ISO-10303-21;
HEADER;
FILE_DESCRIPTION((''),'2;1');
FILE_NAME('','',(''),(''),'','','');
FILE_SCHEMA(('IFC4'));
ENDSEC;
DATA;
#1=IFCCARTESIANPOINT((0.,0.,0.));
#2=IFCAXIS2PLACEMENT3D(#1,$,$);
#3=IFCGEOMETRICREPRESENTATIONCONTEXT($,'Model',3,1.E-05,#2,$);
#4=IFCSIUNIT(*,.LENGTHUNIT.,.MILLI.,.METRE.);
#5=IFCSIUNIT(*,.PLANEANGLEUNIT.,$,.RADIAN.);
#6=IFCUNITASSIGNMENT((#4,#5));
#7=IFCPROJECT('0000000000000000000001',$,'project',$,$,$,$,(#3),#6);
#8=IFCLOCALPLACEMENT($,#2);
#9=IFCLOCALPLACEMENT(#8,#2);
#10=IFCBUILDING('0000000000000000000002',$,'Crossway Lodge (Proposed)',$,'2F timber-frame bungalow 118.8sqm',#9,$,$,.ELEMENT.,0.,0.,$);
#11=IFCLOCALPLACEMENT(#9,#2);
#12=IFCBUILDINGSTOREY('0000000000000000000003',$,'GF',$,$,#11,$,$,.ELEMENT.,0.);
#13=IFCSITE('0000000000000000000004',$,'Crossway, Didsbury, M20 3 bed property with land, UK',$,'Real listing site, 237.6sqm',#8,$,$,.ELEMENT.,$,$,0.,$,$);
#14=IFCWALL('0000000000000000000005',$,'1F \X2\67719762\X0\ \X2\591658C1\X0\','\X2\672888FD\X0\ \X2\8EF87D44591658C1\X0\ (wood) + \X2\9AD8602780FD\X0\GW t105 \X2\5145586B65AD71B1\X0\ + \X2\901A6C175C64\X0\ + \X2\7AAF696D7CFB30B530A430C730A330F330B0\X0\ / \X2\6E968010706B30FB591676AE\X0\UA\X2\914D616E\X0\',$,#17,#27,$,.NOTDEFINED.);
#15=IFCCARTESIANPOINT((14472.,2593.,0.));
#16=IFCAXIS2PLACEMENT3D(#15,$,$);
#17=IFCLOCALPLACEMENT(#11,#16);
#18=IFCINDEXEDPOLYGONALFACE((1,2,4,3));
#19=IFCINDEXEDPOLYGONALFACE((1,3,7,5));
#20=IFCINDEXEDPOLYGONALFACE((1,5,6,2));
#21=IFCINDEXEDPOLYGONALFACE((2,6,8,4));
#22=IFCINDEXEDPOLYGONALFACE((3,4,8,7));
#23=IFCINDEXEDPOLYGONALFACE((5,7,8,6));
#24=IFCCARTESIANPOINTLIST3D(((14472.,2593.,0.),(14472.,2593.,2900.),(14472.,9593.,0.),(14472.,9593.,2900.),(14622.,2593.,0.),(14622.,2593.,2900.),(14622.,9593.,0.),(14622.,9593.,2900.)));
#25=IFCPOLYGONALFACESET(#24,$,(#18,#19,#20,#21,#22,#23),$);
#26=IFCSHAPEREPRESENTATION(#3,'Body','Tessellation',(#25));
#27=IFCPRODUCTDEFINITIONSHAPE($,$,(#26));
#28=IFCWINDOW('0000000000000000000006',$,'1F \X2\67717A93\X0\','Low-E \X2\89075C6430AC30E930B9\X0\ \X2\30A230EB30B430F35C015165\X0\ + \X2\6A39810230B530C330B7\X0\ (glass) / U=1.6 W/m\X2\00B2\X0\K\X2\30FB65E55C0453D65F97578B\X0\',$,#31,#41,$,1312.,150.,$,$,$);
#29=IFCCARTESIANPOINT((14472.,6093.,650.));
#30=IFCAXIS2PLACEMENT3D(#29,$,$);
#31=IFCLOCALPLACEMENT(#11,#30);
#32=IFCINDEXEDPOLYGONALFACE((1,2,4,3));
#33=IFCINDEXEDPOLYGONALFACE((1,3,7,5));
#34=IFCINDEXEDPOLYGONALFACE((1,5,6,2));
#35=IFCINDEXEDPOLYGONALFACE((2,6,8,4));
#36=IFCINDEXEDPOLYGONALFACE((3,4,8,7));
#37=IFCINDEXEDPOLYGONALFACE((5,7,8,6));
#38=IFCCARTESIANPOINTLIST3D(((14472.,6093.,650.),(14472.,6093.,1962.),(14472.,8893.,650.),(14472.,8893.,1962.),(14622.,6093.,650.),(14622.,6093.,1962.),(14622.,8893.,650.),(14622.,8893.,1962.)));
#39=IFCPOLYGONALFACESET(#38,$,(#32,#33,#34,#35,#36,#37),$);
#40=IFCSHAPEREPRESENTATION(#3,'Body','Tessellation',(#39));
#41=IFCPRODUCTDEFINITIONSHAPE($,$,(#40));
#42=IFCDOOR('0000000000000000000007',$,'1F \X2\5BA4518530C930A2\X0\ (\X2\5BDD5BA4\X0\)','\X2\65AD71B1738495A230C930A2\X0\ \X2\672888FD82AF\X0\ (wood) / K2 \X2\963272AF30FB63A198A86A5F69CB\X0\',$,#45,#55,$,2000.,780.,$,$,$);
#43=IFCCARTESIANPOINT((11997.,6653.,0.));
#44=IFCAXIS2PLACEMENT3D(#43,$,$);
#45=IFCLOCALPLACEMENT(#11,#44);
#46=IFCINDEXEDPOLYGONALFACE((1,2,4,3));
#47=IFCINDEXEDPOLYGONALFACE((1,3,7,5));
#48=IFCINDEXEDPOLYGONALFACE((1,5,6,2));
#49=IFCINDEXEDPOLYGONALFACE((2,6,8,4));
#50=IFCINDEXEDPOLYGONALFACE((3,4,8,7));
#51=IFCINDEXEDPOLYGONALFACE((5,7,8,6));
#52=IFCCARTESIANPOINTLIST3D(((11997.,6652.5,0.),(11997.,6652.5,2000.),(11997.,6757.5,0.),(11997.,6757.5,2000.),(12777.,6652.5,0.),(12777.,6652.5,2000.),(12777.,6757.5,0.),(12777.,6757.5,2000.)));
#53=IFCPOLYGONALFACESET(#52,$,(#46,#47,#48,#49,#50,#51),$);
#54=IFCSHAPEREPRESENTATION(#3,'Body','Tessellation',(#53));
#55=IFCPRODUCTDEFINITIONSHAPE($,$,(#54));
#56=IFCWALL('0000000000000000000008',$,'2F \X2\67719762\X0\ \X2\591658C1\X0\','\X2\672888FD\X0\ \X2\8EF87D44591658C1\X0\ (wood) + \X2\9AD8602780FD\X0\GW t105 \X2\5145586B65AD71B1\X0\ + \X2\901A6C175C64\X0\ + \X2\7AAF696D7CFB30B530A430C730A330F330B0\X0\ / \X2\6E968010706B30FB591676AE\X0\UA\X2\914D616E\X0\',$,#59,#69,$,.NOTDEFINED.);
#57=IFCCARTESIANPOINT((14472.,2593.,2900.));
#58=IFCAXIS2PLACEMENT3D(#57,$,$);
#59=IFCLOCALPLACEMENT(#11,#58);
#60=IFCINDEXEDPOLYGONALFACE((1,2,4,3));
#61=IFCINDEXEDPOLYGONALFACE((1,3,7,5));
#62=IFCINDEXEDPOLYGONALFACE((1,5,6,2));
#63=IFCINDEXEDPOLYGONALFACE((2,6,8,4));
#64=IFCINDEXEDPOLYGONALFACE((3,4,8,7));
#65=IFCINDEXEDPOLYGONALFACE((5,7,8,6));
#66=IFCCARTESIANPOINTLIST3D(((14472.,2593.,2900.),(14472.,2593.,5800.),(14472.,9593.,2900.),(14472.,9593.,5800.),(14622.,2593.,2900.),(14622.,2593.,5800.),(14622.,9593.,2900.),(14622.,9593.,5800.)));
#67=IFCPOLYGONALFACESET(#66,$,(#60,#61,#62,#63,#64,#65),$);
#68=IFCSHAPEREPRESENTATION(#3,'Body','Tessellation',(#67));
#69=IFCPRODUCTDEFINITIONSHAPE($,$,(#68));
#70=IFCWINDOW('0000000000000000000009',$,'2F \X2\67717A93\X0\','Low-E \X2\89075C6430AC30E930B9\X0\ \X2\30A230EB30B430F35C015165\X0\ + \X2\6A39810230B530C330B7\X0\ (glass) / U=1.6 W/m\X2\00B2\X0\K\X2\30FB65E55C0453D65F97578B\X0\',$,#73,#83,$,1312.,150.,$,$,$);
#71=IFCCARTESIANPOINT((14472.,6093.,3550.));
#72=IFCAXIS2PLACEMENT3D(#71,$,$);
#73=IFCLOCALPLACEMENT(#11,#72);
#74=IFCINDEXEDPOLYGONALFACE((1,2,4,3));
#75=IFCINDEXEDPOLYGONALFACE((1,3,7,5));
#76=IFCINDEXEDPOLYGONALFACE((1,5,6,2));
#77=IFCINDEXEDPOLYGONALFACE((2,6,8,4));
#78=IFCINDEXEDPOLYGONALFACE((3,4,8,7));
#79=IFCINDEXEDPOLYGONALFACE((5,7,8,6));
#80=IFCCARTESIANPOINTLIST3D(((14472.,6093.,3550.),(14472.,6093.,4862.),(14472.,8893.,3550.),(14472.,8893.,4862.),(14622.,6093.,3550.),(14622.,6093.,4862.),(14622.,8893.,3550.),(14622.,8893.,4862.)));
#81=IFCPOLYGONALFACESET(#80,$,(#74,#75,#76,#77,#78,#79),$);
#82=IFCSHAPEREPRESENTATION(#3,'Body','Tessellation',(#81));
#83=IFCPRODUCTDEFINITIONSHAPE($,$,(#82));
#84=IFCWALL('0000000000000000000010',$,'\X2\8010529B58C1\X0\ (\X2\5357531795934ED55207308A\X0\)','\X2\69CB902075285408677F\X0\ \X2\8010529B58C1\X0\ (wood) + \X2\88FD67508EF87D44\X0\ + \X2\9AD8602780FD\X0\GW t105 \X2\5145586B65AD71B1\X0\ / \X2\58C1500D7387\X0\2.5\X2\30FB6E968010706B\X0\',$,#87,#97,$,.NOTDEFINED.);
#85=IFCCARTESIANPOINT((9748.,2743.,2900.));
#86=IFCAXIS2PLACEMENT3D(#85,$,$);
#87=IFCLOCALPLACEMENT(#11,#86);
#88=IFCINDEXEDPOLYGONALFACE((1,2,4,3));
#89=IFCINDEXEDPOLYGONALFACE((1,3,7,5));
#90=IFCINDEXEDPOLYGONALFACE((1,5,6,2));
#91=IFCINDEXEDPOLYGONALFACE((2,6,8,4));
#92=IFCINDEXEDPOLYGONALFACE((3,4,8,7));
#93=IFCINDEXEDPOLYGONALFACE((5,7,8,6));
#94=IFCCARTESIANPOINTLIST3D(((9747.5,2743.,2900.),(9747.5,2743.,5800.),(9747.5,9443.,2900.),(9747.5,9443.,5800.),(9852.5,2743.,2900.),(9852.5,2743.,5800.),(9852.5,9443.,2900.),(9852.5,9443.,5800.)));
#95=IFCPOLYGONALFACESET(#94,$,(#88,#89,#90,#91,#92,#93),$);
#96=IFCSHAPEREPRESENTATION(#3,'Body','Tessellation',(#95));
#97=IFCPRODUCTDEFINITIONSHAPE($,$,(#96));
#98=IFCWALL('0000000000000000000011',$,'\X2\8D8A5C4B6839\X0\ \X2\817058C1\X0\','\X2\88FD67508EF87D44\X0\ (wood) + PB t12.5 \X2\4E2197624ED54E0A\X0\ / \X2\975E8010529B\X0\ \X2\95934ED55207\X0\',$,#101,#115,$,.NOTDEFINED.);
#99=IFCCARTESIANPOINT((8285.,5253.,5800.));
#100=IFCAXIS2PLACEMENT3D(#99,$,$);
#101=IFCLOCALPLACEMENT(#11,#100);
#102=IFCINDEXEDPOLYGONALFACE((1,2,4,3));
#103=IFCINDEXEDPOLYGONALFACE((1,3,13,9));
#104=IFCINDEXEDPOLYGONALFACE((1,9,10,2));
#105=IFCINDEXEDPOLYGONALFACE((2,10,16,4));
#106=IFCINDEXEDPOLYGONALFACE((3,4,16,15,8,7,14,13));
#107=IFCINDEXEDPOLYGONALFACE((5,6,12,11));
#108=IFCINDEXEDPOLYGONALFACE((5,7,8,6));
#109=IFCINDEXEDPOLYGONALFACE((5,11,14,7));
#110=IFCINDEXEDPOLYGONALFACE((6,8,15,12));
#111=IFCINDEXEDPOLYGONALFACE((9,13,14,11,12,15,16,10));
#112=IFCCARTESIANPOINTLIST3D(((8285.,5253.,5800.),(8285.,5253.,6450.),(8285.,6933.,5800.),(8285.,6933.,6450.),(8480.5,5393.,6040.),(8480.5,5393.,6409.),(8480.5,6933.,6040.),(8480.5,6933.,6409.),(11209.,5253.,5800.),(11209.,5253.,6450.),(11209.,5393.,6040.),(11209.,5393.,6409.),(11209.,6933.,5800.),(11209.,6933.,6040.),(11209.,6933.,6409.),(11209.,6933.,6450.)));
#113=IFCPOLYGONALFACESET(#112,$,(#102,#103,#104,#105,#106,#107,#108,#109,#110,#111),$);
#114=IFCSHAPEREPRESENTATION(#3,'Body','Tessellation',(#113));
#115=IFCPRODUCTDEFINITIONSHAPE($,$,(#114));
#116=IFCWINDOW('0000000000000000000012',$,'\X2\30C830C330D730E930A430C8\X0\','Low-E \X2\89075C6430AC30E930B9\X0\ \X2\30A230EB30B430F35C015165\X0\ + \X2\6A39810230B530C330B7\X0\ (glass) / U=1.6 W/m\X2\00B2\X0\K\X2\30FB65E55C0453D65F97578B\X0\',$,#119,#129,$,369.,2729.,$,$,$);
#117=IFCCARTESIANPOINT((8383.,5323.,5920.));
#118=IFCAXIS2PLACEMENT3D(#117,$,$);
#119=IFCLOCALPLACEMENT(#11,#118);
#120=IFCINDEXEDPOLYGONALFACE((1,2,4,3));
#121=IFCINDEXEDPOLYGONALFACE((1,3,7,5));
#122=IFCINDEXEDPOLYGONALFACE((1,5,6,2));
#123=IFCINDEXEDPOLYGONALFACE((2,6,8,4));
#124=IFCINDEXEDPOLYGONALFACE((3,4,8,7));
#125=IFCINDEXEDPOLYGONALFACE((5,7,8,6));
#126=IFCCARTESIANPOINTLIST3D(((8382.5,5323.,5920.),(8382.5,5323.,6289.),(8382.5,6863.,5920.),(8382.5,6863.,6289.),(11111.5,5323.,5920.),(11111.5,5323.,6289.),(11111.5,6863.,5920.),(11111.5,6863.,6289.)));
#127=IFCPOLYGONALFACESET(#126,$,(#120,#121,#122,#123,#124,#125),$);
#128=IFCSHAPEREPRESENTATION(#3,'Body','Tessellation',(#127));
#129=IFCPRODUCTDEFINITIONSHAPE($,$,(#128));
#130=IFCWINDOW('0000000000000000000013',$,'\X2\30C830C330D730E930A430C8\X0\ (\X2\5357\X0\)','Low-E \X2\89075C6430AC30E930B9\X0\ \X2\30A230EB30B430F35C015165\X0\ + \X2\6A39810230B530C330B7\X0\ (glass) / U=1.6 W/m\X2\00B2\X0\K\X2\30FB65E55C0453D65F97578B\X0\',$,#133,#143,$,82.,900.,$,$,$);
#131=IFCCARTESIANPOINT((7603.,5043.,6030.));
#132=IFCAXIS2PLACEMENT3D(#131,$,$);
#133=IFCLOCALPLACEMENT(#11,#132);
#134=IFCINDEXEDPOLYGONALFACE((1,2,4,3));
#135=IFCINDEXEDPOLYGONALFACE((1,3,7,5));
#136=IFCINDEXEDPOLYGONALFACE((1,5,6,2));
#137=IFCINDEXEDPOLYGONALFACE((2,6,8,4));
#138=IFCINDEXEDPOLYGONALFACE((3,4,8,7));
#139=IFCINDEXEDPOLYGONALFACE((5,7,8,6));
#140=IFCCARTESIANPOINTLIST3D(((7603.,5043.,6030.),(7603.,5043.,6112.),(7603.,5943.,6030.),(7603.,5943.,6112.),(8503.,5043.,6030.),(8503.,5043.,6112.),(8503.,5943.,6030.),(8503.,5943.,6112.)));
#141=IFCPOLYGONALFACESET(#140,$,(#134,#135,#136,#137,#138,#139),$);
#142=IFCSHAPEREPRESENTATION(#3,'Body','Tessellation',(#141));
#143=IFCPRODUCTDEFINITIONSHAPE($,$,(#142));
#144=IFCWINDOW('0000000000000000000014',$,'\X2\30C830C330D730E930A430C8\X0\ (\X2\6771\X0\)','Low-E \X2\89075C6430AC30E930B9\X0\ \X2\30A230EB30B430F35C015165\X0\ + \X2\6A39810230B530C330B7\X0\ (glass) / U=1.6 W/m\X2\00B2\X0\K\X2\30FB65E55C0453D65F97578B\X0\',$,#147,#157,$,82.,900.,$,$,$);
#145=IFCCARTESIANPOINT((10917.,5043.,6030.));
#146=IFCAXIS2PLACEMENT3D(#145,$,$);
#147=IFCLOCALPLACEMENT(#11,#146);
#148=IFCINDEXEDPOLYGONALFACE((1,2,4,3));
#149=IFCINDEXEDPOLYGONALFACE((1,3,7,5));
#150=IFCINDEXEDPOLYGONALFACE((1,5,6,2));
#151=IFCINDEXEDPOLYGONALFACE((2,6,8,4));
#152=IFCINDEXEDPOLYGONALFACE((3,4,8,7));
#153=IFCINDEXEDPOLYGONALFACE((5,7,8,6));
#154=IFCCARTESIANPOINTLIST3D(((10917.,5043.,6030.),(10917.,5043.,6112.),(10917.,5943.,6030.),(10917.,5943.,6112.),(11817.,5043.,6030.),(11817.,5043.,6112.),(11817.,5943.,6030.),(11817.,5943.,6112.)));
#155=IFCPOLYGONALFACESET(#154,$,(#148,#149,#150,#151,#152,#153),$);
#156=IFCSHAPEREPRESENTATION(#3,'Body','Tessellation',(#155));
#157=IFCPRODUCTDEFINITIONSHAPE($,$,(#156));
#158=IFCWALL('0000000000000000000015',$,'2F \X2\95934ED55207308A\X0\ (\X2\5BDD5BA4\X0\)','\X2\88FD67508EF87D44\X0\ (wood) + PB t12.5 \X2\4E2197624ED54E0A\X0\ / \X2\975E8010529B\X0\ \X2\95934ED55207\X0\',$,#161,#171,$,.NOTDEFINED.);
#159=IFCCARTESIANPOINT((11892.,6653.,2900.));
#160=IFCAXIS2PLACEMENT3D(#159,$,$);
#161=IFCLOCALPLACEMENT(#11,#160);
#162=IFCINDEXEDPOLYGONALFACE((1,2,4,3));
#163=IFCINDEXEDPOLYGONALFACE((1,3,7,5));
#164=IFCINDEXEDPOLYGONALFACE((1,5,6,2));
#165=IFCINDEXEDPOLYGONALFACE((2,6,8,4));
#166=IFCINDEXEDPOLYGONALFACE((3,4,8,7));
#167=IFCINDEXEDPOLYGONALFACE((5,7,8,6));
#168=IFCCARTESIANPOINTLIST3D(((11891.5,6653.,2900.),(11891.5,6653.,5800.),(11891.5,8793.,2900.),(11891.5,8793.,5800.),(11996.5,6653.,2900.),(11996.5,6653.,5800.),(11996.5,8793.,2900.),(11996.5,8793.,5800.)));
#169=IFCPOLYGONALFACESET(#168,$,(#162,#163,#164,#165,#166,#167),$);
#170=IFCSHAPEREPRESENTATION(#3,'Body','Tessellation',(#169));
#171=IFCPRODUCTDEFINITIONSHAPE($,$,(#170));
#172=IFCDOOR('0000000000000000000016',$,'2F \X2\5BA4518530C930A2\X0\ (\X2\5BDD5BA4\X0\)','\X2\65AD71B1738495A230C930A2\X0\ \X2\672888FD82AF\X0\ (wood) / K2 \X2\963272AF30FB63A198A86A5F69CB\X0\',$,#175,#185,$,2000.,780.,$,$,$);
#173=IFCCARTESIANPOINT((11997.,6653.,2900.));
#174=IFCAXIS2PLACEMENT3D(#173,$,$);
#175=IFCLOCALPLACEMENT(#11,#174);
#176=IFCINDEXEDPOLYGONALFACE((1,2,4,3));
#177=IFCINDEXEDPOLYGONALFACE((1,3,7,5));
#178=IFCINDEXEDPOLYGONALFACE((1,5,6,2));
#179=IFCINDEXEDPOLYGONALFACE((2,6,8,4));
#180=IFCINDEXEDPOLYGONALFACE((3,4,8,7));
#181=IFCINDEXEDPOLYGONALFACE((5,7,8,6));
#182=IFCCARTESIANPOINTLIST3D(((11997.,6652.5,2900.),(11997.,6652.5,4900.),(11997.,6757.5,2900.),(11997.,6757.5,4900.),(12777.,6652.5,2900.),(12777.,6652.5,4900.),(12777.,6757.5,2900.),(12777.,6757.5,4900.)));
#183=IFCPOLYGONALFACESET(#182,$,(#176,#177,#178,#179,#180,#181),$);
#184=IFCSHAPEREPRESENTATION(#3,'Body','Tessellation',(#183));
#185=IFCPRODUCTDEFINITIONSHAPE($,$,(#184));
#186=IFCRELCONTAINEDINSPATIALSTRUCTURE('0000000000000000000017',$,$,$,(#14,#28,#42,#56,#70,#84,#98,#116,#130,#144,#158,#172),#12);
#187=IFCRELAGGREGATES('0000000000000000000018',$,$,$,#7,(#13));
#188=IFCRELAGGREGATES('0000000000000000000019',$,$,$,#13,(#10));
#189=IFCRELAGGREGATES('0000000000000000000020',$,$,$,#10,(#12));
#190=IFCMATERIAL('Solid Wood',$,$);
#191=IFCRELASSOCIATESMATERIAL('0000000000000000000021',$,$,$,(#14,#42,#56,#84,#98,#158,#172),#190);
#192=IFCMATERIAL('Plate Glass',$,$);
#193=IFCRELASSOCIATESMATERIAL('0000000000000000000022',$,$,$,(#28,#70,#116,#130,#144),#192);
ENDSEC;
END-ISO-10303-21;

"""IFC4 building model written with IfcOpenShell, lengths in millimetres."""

from ifc_helpers import new_model, si_unit, frame, frame_2d, origin, place, context, project, spatial, rectangle, extrude, material, element, fill, save


model = new_model("IFC4")

# Units and contexts
model_context = context("Model", 3, precision=1e-05, world=origin())
ifc_project = project(units=[si_unit("LENGTHUNIT", "METRE", prefix="MILLI"), si_unit("PLANEANGLEUNIT", "RADIAN")], contexts=[model_context])

# Site, building, storey
site_placement = place(None, origin())
site = spatial("IfcSite", under=ifc_project, at=site_placement, Name="Crossway, Didsbury, M20 3 bed property with land, UK", ObjectType="Real listing site, 237.6sqm", CompositionType="ELEMENT", RefElevation=0.0)
building_placement = place(site_placement, origin())
building = spatial("IfcBuilding", under=site, at=building_placement, Name="Crossway Lodge (Proposed)", ObjectType="2F timber-frame bungalow 118.8sqm", CompositionType="ELEMENT", ElevationOfRefHeight=0.0, ElevationOfTerrain=0.0)
storey_placement = place(building_placement, origin())
storey = spatial("IfcBuildingStorey", under=building, at=storey_placement, Name="GF", CompositionType="ELEMENT", Elevation=0.0)

# Wall, opening, window
ifc_material_1 = material(Name="Solid Wood")
wall_1_placement = place(storey_placement, frame((14472.0, 2593.0, 0.0)))
wall_1 = element("IfcWall", 1, at=wall_1_placement, inside=storey, material=ifc_material_1, Name="1F 東面 外壁", Description="木製 軸組外壁 (wood) + 高性能GW t105 充填断熱 + 通気層 + 窯業系サイディング / 準耐火・外皮UA配慮", PredefinedType="NOTDEFINED", context=model_context, shape_type="SweptSolid", body=[
    extrude(rectangle(XDim=150.0, YDim=7000.0, at=frame_2d((75.0, 3500.0))), frame((14472.0, 2593.0, 0.0)), (0.0, 0.0, 1.0), 2900.0),
])
opening_1_placement = place(storey_placement, frame((14472.0, 6093.0, 650.0)))
opening_1 = element("IfcOpeningElement", 2, at=opening_1_placement, cuts=wall_1, PredefinedType="NOTDEFINED", context=model_context, shape_type="SweptSolid", body=[
    extrude(rectangle(XDim=150.0, YDim=2800.0, at=frame_2d((75.0, 1400.0))), frame((14472.0, 6093.0, 650.0)), (0.0, 0.0, 1.0), 1312.0),
])
ifc_material_2 = material(Name="Plate Glass")
window_1_placement = place(storey_placement, frame((14472.0, 6093.0, 650.0)))
window_1 = element("IfcWindow", 3, at=window_1_placement, inside=storey, material=ifc_material_2, Name="1F 東窓", Description="Low-E 複層ガラス アルゴン封入 + 樹脂サッシ (glass) / U=1.6 W/m²K・日射取得型", OverallHeight=1312.0, OverallWidth=150.0, context=model_context, shape_type="SweptSolid", body=[
    extrude(rectangle(XDim=150.0, YDim=2800.0, at=frame_2d((75.0, 1400.0))), frame((14472.0, 6093.0, 650.0)), (0.0, 0.0, 1.0), 1312.0),
])
fill(opening_1, window_1)

# Door
door_1_placement = place(storey_placement, frame((11997.0, 6653.0, 0.0)))
element("IfcDoor", 4, at=door_1_placement, inside=storey, material=ifc_material_1, Name="1F 室内ドア (寝室)", Description="断熱玄関ドア 木製芯 (wood) / K2 防犯・採風機構", OverallHeight=2000.0, OverallWidth=780.0, context=model_context, shape_type="SweptSolid", body=[
    extrude(rectangle(XDim=780.0, YDim=105.0, at=frame_2d((390.0, 52.0))), frame((11997.0, 6653.0, 0.0)), (0.0, 0.0, 1.0), 2000.0),
])

# Wall, opening, window
wall_2_placement = place(storey_placement, frame((14472.0, 2593.0, 2900.0)))
wall_2 = element("IfcWall", 5, at=wall_2_placement, inside=storey, material=ifc_material_1, Name="2F 東面 外壁", Description="木製 軸組外壁 (wood) + 高性能GW t105 充填断熱 + 通気層 + 窯業系サイディング / 準耐火・外皮UA配慮", PredefinedType="NOTDEFINED", context=model_context, shape_type="SweptSolid", body=[
    extrude(rectangle(XDim=150.0, YDim=7000.0, at=frame_2d((75.0, 3500.0))), frame((14472.0, 2593.0, 2900.0)), (0.0, 0.0, 1.0), 2900.0),
])
opening_2_placement = place(storey_placement, frame((14472.0, 6093.0, 3550.0)))
opening_2 = element("IfcOpeningElement", 6, at=opening_2_placement, cuts=wall_2, PredefinedType="NOTDEFINED", context=model_context, shape_type="SweptSolid", body=[
    extrude(rectangle(XDim=150.0, YDim=2800.0, at=frame_2d((75.0, 1400.0))), frame((14472.0, 6093.0, 3550.0)), (0.0, 0.0, 1.0), 1312.0),
])
window_2_placement = place(storey_placement, frame((14472.0, 6093.0, 3550.0)))
window_2 = element("IfcWindow", 7, at=window_2_placement, inside=storey, material=ifc_material_2, Name="2F 東窓", Description="Low-E 複層ガラス アルゴン封入 + 樹脂サッシ (glass) / U=1.6 W/m²K・日射取得型", OverallHeight=1312.0, OverallWidth=150.0, context=model_context, shape_type="SweptSolid", body=[
    extrude(rectangle(XDim=150.0, YDim=2800.0, at=frame_2d((75.0, 1400.0))), frame((14472.0, 6093.0, 3550.0)), (0.0, 0.0, 1.0), 1312.0),
])
fill(opening_2, window_2)

# Wall
wall_3_placement = place(storey_placement, frame((9748.0, 2743.0, 2900.0)))
element("IfcWall", 8, at=wall_3_placement, inside=storey, material=ifc_material_1, Name="耐力壁 (南北間仕切り)", Description="構造用合板 耐力壁 (wood) + 製材軸組 + 高性能GW t105 充填断熱 / 壁倍率2.5・準耐火", PredefinedType="NOTDEFINED", context=model_context, shape_type="SweptSolid", body=[
    extrude(rectangle(XDim=105.0, YDim=6700.0, at=frame_2d((52.0, 3350.0))), frame((9748.0, 2743.0, 2900.0)), (0.0, 0.0, 1.0), 2900.0),
])

# Wall, openings, windows
wall_4_placement = place(storey_placement, frame((8285.0, 5253.0, 5800.0)))
wall_4 = element("IfcWall", 9, at=wall_4_placement, inside=storey, material=ifc_material_1, Name="越屋根 腰壁", Description="製材軸組 (wood) + PB t12.5 両面仕上 / 非耐力 間仕切", PredefinedType="NOTDEFINED", context=model_context, shape_type="SweptSolid", body=[
    extrude(rectangle(XDim=2924.0, YDim=1680.0, at=frame_2d((1462.0, 840.0))), frame((8285.0, 5253.0, 5800.0)), (0.0, 0.0, 1.0), 650.0),
])
opening_3_placement = place(storey_placement, frame((8383.0, 5323.0, 5920.0)))
opening_3 = element("IfcOpeningElement", 10, at=opening_3_placement, cuts=wall_4, PredefinedType="NOTDEFINED", context=model_context, shape_type="SweptSolid", body=[
    extrude(rectangle(XDim=2729.0, YDim=1540.0, at=frame_2d((1364.0, 770.0))), frame((8383.0, 5323.0, 5920.0)), (0.0, 0.0, 1.0), 369.0),
])
opening_4_placement = place(storey_placement, frame((7603.0, 5043.0, 6030.0)))
opening_4 = element("IfcOpeningElement", 11, at=opening_4_placement, cuts=wall_4, PredefinedType="NOTDEFINED", context=model_context, shape_type="SweptSolid", body=[
    extrude(rectangle(XDim=900.0, YDim=900.0, at=frame_2d((450.0, 450.0))), frame((7603.0, 5043.0, 6030.0)), (0.0, 0.0, 1.0), 82.0),
])
opening_5_placement = place(storey_placement, frame((10917.0, 5043.0, 6030.0)))
opening_5 = element("IfcOpeningElement", 12, at=opening_5_placement, cuts=wall_4, PredefinedType="NOTDEFINED", context=model_context, shape_type="SweptSolid", body=[
    extrude(rectangle(XDim=900.0, YDim=900.0, at=frame_2d((450.0, 450.0))), frame((10917.0, 5043.0, 6030.0)), (0.0, 0.0, 1.0), 82.0),
])
window_3_placement = place(storey_placement, frame((8383.0, 5323.0, 5920.0)))
window_3 = element("IfcWindow", 13, at=window_3_placement, inside=storey, material=ifc_material_2, Name="トップライト", Description="Low-E 複層ガラス アルゴン封入 + 樹脂サッシ (glass) / U=1.6 W/m²K・日射取得型", OverallHeight=369.0, OverallWidth=2729.0, context=model_context, shape_type="SweptSolid", body=[
    extrude(rectangle(XDim=2729.0, YDim=1540.0, at=frame_2d((1364.0, 770.0))), frame((8383.0, 5323.0, 5920.0)), (0.0, 0.0, 1.0), 369.0),
])
fill(opening_3, window_3)
window_4_placement = place(storey_placement, frame((7603.0, 5043.0, 6030.0)))
window_4 = element("IfcWindow", 14, at=window_4_placement, inside=storey, material=ifc_material_2, Name="トップライト (南)", Description="Low-E 複層ガラス アルゴン封入 + 樹脂サッシ (glass) / U=1.6 W/m²K・日射取得型", OverallHeight=82.0, OverallWidth=900.0, context=model_context, shape_type="SweptSolid", body=[
    extrude(rectangle(XDim=900.0, YDim=900.0, at=frame_2d((450.0, 450.0))), frame((7603.0, 5043.0, 6030.0)), (0.0, 0.0, 1.0), 82.0),
])
fill(opening_4, window_4)
window_5_placement = place(storey_placement, frame((10917.0, 5043.0, 6030.0)))
window_5 = element("IfcWindow", 15, at=window_5_placement, inside=storey, material=ifc_material_2, Name="トップライト (東)", Description="Low-E 複層ガラス アルゴン封入 + 樹脂サッシ (glass) / U=1.6 W/m²K・日射取得型", OverallHeight=82.0, OverallWidth=900.0, context=model_context, shape_type="SweptSolid", body=[
    extrude(rectangle(XDim=900.0, YDim=900.0, at=frame_2d((450.0, 450.0))), frame((10917.0, 5043.0, 6030.0)), (0.0, 0.0, 1.0), 82.0),
])
fill(opening_5, window_5)

# Wall
wall_5_placement = place(storey_placement, frame((11892.0, 6653.0, 2900.0)))
element("IfcWall", 16, at=wall_5_placement, inside=storey, material=ifc_material_1, Name="2F 間仕切り (寝室)", Description="製材軸組 (wood) + PB t12.5 両面仕上 / 非耐力 間仕切", PredefinedType="NOTDEFINED", context=model_context, shape_type="SweptSolid", body=[
    extrude(rectangle(XDim=105.0, YDim=2140.0, at=frame_2d((52.0, 1070.0))), frame((11892.0, 6653.0, 2900.0)), (0.0, 0.0, 1.0), 2900.0),
])

# Door
door_2_placement = place(storey_placement, frame((11997.0, 6653.0, 2900.0)))
element("IfcDoor", 17, at=door_2_placement, inside=storey, material=ifc_material_1, Name="2F 室内ドア (寝室)", Description="断熱玄関ドア 木製芯 (wood) / K2 防犯・採風機構", OverallHeight=2000.0, OverallWidth=780.0, context=model_context, shape_type="SweptSolid", body=[
    extrude(rectangle(XDim=780.0, YDim=105.0, at=frame_2d((390.0, 52.0))), frame((11997.0, 6653.0, 2900.0)), (0.0, 0.0, 1.0), 2000.0),
])

save(model, "model.ifc")
